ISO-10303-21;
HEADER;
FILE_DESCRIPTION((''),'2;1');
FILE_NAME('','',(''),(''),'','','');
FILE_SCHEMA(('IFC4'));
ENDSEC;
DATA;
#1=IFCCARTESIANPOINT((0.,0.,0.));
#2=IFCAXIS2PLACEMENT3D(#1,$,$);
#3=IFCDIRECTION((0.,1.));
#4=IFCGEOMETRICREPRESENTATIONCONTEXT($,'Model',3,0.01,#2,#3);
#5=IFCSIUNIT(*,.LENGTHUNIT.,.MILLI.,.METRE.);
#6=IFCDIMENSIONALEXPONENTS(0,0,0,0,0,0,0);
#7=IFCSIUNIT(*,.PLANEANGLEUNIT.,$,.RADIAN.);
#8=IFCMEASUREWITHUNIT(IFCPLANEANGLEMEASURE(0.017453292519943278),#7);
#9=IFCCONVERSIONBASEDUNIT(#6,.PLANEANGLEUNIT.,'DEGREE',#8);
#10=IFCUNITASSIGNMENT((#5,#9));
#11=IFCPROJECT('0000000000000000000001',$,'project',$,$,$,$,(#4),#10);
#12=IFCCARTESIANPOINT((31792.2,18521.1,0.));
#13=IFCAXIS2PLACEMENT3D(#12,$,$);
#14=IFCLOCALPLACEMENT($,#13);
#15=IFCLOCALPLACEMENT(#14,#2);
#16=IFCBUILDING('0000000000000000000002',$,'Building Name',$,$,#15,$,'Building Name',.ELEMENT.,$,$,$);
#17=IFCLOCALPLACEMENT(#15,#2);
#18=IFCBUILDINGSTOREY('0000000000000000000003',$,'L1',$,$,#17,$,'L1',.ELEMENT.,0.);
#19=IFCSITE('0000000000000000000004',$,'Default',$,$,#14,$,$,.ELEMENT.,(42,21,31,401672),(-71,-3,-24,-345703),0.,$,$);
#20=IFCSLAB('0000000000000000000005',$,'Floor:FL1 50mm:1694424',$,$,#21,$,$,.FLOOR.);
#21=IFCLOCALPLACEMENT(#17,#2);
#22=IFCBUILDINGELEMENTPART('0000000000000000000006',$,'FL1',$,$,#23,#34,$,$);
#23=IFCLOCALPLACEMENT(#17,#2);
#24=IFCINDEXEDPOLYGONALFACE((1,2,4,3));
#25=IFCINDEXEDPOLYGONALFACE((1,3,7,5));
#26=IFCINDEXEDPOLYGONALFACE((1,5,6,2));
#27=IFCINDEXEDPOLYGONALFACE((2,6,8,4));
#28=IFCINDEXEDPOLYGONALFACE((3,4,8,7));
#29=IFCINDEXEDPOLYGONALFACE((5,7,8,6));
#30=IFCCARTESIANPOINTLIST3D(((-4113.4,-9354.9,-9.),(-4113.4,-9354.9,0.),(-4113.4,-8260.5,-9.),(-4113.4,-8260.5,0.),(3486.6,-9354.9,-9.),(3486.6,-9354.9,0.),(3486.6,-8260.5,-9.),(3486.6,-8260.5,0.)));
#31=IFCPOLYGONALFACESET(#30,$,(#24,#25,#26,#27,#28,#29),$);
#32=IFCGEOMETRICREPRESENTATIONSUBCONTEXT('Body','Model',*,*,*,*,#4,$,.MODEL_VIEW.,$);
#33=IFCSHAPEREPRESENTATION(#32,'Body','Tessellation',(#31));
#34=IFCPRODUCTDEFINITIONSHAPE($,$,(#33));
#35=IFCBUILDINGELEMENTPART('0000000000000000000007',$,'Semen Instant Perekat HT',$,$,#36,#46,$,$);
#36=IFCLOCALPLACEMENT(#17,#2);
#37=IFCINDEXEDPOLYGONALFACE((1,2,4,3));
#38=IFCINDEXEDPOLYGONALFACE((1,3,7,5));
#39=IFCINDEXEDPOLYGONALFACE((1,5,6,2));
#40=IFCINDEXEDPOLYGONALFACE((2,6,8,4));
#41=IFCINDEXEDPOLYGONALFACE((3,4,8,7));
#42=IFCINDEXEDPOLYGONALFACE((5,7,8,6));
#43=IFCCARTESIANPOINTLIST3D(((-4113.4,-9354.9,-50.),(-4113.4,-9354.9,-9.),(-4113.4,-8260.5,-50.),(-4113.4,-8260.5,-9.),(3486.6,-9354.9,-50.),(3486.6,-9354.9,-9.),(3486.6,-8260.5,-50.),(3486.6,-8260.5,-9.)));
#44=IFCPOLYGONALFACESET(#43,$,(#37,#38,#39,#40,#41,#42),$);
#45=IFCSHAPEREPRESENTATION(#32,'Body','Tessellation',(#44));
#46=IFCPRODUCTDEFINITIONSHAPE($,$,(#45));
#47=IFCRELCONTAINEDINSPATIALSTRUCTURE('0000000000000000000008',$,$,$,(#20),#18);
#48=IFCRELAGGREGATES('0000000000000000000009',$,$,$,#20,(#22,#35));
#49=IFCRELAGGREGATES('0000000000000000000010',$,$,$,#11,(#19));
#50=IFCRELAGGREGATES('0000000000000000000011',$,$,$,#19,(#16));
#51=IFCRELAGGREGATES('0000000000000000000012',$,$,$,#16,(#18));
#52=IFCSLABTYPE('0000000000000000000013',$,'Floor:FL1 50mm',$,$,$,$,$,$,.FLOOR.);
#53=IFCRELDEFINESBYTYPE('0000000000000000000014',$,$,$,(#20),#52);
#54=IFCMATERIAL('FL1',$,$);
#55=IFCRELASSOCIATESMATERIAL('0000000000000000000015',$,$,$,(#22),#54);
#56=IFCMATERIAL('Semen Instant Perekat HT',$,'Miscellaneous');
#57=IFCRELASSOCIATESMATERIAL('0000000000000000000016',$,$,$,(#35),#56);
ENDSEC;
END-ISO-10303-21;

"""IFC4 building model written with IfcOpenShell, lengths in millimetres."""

from ifc_helpers import new_model, entity, si_unit, converted_unit, direction, frame, origin, place, context, subcontext, project, spatial, indexed_curve, outline, extrude, material, type_object, element, aggregate, save


model = new_model("IFC4")

# Units and contexts
model_context = context("Model", 3, precision=0.01, world=origin(), true_north=direction((0.0, 1.0)))
body_context = subcontext(model_context, "Body", "Model", "MODEL_VIEW")
ifc_project = project(units=[si_unit("LENGTHUNIT", "METRE", prefix="MILLI"), converted_unit("PLANEANGLEUNIT", "DEGREE", entity("IfcPlaneAngleMeasure", 0.017453292519943278), si_unit("PLANEANGLEUNIT", "RADIAN"), dimensions=[0, 0, 0, 0, 0, 0, 0])], contexts=[model_context])

# Site, building, storey
site_placement = place(None, frame((31792.2, 18521.1, 0.0)))
site = spatial("IfcSite", under=ifc_project, at=site_placement, Name="Default", CompositionType="ELEMENT", RefLatitude=(42, 21, 31, 401672), RefLongitude=(-71, -3, -24, -345703), RefElevation=0.0)
building_placement = place(site_placement, origin())
building = spatial("IfcBuilding", under=site, at=building_placement, Name="Building Name", LongName="Building Name", CompositionType="ELEMENT")
storey_placement = place(building_placement, origin())
storey = spatial("IfcBuildingStorey", under=building, at=storey_placement, Name="L1", LongName="L1", CompositionType="ELEMENT", Elevation=0.0)

# Slab, building element parts
slab_type = type_object("IfcSlabType", Name="Floor:FL1 50mm", PredefinedType="FLOOR")
ifc_material_1 = material(Name="FL1")
ifc_material_2 = material(Name="Semen Instant Perekat HT", Category="Miscellaneous")
slab_1_placement = place(storey_placement, origin())
slab_1 = element("IfcSlab", 1, at=slab_1_placement, inside=storey, type_object=slab_type, Name="Floor:FL1 50mm:1694424", PredefinedType="FLOOR")
building_element_part_1_placement = place(slab_1_placement, origin())
building_element_part_1 = element("IfcBuildingElementPart", 2, at=building_element_part_1_placement, material=ifc_material_1, Name="FL1", context=body_context, shape_type="SweptSolid", body=[
    extrude(outline(indexed_curve([(-547.2, -3800.0), (547.2, -3800.0), (547.2, 3800.0), (-547.2, 3800.0), (-547.2, -3800.0)], self_intersect=False)), frame((-313.4, -8807.7, -9.0), z_axis=(0.0, 0.0, 1.0), x_axis=(0.0, -1.0, 0.0)), (0.0, 0.0, 1.0), 9.0),
])
building_element_part_2_placement = place(slab_1_placement, origin())
building_element_part_2 = element("IfcBuildingElementPart", 3, at=building_element_part_2_placement, material=ifc_material_2, Name="Semen Instant Perekat HT", context=body_context, shape_type="SweptSolid", body=[
    extrude(outline(indexed_curve([(-547.2, -3800.0), (547.2, -3800.0), (547.2, 3800.0), (-547.2, 3800.0), (-547.2, -3800.0)], self_intersect=False)), frame((-313.4, -8807.7, -50.0), z_axis=(0.0, 0.0, 1.0), x_axis=(0.0, -1.0, 0.0)), (0.0, 0.0, 1.0), 41.0),
])
aggregate(slab_1, [building_element_part_1, building_element_part_2])

save(model, "model.ifc")
